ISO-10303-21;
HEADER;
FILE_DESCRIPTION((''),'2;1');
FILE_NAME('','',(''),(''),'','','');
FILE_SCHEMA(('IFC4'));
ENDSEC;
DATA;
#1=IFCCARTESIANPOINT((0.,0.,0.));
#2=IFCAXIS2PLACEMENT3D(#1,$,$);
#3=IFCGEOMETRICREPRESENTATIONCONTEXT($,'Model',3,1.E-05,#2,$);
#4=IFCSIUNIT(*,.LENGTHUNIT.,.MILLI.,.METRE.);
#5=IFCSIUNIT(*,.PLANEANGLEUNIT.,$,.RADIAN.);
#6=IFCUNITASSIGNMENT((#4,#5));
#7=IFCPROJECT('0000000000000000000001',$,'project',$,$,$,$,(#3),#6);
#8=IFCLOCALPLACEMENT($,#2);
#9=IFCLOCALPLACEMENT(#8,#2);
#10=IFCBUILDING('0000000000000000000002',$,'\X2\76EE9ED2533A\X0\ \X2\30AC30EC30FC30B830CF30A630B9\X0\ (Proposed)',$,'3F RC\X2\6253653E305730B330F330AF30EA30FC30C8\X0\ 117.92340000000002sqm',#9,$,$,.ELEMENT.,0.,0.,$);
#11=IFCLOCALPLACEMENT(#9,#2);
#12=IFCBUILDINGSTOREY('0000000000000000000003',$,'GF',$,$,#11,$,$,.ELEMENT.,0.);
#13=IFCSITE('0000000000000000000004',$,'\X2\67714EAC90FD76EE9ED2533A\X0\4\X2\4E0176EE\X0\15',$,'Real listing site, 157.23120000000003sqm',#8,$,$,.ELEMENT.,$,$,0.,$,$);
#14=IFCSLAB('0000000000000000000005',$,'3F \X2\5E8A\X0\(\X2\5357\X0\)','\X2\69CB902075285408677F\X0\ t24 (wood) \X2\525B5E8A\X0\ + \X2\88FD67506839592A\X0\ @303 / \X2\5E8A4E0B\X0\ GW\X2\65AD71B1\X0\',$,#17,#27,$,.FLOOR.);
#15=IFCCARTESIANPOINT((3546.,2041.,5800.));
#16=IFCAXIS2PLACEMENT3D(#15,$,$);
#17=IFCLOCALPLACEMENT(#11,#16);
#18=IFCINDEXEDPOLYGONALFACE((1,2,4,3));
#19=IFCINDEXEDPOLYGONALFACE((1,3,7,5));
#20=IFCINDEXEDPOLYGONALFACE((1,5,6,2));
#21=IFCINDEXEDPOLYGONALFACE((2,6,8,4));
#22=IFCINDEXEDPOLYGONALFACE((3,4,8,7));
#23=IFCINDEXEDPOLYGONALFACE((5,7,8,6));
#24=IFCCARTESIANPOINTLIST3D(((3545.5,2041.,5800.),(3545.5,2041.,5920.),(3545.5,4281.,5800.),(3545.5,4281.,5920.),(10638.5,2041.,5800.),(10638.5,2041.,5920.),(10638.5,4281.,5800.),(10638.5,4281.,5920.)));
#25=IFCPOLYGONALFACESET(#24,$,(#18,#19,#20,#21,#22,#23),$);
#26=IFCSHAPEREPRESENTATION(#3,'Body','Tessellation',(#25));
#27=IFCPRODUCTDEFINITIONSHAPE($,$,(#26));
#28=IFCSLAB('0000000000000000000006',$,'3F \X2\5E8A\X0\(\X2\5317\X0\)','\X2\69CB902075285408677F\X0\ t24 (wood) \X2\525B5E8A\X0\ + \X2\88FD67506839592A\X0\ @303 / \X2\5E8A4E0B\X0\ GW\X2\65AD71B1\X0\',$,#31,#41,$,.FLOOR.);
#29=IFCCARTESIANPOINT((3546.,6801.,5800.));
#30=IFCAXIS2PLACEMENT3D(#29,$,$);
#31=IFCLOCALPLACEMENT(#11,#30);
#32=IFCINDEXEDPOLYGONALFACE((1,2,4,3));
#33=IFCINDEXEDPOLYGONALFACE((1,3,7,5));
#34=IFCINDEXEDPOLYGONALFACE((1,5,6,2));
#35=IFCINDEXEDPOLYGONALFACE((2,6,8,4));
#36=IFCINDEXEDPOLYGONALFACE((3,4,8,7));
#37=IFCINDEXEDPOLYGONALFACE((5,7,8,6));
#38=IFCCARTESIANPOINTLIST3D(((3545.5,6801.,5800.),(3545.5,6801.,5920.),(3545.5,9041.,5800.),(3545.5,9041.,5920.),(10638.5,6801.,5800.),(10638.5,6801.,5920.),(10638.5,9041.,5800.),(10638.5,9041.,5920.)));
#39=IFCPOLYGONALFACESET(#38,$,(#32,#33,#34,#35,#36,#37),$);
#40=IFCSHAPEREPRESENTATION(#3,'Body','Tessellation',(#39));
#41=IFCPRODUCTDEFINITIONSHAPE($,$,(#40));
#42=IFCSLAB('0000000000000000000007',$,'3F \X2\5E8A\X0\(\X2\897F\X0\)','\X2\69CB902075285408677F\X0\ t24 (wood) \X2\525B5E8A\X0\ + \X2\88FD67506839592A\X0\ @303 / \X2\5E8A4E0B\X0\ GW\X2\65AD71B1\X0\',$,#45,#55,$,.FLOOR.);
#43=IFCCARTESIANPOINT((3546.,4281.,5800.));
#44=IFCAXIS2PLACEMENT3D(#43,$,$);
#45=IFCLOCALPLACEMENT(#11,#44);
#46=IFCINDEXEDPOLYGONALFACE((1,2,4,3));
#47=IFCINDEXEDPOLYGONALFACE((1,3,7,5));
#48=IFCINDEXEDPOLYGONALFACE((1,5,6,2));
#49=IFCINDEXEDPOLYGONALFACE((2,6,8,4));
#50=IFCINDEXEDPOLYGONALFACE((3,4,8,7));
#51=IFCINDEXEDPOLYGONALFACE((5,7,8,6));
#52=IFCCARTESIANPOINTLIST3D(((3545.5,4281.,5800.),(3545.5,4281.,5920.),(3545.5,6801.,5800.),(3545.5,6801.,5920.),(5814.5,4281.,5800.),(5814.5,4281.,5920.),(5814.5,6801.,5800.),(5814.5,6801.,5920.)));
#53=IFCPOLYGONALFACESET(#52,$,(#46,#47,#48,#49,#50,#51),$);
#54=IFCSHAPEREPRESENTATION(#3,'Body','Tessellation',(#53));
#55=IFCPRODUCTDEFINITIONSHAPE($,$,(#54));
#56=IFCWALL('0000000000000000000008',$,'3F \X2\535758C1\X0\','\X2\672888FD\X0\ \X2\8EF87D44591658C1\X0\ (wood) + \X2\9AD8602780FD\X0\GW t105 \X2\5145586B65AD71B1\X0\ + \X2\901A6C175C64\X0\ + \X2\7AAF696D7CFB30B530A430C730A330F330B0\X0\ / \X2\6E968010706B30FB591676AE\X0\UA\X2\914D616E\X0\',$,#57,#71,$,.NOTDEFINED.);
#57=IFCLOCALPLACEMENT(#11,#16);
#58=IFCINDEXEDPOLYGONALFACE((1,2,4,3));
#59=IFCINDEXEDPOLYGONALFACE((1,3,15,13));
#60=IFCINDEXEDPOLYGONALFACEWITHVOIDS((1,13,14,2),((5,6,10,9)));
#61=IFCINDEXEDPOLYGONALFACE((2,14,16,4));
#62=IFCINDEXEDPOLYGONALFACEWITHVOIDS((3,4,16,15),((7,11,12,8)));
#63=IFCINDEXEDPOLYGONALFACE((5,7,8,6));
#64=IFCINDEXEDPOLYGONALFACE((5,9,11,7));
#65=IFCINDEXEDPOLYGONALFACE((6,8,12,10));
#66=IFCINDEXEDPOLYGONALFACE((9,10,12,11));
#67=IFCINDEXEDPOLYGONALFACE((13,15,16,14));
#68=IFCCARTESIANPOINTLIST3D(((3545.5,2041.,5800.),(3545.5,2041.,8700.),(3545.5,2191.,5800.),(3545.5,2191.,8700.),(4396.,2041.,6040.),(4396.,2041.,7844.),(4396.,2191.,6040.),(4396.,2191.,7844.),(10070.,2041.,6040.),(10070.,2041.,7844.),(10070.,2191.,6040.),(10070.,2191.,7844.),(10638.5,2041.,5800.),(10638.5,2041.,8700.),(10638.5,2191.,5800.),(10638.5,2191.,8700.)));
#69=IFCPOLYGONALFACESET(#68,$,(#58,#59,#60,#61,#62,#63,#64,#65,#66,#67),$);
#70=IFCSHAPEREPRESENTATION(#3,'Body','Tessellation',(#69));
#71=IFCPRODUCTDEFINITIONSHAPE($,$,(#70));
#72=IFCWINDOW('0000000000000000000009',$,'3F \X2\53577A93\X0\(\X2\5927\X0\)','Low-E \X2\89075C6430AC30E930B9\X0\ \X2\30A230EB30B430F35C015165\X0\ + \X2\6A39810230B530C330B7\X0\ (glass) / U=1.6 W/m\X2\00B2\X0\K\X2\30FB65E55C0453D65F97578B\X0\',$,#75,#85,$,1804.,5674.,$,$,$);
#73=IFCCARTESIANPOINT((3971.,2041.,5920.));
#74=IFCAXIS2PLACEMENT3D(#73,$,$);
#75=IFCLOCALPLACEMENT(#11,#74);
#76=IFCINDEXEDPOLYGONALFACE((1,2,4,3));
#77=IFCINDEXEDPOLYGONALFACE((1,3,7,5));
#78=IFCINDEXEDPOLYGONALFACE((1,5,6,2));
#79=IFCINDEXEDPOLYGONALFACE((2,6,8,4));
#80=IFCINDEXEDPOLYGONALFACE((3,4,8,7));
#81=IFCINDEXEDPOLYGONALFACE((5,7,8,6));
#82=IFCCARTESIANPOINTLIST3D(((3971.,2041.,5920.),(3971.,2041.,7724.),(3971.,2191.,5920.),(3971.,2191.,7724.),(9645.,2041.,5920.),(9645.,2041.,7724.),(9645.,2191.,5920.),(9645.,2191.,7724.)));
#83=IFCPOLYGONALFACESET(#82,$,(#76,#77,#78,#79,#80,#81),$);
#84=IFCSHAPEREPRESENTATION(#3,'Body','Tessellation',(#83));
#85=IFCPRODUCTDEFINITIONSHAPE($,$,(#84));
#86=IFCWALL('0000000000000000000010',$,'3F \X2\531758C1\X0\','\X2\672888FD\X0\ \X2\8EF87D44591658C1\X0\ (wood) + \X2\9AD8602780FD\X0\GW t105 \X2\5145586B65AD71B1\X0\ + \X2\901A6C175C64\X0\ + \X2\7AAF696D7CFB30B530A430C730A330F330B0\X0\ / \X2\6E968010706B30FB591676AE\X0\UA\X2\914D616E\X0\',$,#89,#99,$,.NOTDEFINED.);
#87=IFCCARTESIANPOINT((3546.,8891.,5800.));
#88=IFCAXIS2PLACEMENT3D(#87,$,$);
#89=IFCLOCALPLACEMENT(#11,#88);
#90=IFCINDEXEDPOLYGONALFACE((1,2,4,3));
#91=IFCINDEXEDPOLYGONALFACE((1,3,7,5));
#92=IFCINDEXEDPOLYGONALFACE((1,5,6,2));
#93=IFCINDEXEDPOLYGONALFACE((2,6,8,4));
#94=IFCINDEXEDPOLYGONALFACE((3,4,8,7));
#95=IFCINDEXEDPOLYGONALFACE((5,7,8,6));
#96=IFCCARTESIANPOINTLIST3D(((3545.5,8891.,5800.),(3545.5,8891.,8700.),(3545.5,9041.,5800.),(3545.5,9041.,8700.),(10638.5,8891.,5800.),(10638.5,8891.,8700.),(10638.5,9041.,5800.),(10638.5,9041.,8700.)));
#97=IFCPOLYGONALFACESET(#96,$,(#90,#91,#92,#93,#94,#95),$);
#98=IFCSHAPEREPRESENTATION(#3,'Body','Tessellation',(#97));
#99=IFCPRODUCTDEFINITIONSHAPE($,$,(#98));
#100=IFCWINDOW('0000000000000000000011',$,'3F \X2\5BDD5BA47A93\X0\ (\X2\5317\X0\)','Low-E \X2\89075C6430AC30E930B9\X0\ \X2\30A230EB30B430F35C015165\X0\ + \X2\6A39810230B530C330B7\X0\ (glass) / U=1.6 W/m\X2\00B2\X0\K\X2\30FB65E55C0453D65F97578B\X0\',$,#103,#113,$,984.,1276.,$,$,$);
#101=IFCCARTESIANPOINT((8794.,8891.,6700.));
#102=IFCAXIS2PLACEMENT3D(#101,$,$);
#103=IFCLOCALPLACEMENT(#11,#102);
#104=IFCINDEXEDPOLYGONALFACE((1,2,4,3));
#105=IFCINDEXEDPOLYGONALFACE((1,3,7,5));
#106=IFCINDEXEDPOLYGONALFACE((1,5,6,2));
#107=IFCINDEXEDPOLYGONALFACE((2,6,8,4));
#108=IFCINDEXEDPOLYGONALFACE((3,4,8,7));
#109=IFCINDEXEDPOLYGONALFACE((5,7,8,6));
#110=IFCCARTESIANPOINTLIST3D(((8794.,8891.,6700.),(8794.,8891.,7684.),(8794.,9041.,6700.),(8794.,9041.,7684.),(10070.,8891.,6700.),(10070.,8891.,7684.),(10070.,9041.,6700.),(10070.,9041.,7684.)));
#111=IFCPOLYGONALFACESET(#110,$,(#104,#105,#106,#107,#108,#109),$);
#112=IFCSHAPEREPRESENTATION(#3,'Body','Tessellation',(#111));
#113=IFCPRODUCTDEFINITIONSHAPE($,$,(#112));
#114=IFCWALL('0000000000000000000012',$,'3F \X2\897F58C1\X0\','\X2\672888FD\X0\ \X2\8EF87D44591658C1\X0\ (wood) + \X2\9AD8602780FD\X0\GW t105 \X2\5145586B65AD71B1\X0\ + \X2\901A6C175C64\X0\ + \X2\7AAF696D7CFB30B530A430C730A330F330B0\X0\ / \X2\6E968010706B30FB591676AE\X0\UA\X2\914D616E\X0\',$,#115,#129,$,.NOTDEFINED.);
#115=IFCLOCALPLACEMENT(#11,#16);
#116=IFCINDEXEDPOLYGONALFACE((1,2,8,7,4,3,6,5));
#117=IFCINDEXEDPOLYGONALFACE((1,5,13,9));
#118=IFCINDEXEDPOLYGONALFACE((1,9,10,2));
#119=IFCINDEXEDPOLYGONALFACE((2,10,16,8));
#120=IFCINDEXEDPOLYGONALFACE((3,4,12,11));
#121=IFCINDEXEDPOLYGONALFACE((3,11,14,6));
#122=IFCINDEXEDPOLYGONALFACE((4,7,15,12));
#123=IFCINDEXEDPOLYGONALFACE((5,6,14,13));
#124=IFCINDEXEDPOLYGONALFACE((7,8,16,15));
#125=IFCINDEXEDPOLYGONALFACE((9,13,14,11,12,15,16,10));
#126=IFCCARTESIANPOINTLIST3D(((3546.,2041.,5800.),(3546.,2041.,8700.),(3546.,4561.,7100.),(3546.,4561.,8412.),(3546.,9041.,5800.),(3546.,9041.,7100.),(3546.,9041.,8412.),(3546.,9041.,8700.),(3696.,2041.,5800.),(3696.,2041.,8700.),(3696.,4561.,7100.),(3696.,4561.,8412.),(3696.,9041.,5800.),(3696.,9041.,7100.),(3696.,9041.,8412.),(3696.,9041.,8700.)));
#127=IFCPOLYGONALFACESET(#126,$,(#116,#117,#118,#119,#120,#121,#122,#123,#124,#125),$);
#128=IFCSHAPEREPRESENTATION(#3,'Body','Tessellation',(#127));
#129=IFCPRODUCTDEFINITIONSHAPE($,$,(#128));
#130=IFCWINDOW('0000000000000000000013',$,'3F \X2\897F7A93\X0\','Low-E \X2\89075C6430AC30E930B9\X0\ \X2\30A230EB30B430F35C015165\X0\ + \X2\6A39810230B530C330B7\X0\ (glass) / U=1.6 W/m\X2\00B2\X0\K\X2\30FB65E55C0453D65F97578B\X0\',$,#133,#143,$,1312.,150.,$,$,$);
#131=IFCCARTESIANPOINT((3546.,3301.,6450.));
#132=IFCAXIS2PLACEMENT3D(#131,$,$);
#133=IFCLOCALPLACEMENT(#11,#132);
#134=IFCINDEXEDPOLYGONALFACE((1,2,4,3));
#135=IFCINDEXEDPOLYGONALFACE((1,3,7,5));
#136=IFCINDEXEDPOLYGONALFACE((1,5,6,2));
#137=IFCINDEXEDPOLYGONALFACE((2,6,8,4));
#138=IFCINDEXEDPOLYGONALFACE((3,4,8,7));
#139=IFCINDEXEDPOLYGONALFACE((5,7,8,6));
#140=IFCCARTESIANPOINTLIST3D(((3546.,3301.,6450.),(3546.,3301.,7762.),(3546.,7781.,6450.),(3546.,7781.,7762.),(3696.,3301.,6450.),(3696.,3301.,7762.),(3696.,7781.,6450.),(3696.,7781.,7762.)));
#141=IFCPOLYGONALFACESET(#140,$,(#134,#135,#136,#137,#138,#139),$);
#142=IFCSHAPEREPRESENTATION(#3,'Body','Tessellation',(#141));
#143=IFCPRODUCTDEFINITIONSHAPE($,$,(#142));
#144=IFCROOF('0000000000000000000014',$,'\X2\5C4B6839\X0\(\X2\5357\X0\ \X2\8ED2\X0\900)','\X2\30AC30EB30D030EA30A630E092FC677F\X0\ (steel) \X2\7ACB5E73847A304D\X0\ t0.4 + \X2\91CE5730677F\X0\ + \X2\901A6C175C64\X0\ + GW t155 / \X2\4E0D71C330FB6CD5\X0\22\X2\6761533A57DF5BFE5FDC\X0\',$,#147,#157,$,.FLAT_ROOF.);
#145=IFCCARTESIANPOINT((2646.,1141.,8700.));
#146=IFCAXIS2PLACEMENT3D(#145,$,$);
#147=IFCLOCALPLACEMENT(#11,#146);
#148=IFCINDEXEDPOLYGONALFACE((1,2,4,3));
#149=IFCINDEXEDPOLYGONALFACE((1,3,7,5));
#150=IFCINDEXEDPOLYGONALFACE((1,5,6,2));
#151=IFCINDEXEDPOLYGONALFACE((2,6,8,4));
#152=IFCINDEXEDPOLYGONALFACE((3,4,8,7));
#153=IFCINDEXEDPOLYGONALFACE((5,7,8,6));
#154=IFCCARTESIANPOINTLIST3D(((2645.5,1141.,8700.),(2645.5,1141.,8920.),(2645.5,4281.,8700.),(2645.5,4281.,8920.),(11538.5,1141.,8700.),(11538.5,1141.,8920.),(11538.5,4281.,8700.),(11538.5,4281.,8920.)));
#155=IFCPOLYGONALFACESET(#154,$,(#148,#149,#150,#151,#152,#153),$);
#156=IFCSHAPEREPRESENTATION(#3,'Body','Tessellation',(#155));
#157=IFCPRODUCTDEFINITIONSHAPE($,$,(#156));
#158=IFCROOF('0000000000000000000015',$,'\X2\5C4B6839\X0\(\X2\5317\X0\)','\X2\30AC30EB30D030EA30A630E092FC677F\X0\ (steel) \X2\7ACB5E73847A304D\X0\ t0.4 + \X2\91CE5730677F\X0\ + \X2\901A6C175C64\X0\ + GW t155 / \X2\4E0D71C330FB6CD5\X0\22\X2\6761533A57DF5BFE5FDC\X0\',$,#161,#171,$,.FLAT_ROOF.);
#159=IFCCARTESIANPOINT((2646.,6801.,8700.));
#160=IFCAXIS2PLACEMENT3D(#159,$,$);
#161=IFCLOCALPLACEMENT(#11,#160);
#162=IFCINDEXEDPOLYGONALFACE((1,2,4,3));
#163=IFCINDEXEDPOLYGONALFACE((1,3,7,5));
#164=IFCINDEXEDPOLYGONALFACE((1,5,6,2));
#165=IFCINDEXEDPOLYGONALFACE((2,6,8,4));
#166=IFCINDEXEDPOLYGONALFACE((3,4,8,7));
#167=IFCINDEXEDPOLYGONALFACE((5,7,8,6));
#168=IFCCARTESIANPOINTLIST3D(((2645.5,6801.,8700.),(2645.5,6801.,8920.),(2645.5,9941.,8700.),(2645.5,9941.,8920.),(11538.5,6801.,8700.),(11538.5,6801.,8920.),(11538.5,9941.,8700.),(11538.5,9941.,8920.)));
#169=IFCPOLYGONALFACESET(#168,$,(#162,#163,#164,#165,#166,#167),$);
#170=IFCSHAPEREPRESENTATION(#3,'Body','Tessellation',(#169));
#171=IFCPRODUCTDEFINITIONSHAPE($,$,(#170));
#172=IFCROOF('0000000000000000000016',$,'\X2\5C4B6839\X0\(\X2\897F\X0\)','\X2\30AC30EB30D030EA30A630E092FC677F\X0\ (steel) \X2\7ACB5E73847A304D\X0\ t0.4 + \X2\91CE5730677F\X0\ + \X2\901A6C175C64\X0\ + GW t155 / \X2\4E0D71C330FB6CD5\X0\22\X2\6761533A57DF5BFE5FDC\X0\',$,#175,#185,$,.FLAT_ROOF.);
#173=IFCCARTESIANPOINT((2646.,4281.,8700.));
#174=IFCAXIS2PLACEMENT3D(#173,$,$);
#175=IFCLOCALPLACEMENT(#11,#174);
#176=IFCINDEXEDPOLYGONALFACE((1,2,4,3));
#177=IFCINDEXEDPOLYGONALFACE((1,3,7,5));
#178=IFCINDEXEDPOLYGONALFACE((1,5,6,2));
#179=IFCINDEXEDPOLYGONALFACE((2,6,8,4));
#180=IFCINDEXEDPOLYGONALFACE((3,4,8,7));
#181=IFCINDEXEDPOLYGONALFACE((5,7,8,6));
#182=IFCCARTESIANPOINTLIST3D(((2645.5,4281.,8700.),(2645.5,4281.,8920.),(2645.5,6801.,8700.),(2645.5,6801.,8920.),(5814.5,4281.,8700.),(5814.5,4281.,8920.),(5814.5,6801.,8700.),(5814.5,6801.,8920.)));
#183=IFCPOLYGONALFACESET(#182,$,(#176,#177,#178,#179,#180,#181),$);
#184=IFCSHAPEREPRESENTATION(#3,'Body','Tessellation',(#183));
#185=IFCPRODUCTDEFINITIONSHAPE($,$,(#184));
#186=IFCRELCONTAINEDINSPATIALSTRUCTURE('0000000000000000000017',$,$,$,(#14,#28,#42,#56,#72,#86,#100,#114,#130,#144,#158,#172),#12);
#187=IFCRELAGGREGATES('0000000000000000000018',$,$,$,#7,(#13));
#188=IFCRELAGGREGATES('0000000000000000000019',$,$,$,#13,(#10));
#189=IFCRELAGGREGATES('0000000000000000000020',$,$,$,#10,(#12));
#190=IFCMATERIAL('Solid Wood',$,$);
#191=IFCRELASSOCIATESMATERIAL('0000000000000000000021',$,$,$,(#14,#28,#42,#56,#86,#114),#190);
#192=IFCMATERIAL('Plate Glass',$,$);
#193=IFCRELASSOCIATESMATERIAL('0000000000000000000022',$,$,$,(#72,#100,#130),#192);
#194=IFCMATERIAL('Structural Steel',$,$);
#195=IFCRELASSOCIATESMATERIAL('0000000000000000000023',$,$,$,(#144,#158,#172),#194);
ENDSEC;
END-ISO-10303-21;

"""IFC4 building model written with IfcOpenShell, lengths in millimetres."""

from ifc_helpers import new_model, si_unit, frame, frame_2d, origin, place, context, project, spatial, rectangle, extrude, material, element, fill, save


model = new_model("IFC4")

# Units and contexts
model_context = context("Model", 3, precision=1e-05, world=origin())
ifc_project = project(units=[si_unit("LENGTHUNIT", "METRE", prefix="MILLI"), si_unit("PLANEANGLEUNIT", "RADIAN")], contexts=[model_context])

# Site, building, storey
site_placement = place(None, origin())
site = spatial("IfcSite", under=ifc_project, at=site_placement, Name="東京都目黒区4丁目15", ObjectType="Real listing site, 157.23120000000003sqm", CompositionType="ELEMENT", RefElevation=0.0)
building_placement = place(site_placement, origin())
building = spatial("IfcBuilding", under=site, at=building_placement, Name="目黒区 ガレージハウス (Proposed)", ObjectType="3F RC打放しコンクリート 117.92340000000002sqm", CompositionType="ELEMENT", ElevationOfRefHeight=0.0, ElevationOfTerrain=0.0)
storey_placement = place(building_placement, origin())
storey = spatial("IfcBuildingStorey", under=building, at=storey_placement, Name="GF", CompositionType="ELEMENT", Elevation=0.0)

# Slabs
ifc_material_1 = material(Name="Solid Wood")
slab_1_placement = place(storey_placement, frame((3546.0, 2041.0, 5800.0)))
element("IfcSlab", 1, at=slab_1_placement, inside=storey, material=ifc_material_1, Name="3F 床(南)", Description="構造用合板 t24 (wood) 剛床 + 製材根太 @303 / 床下 GW断熱", PredefinedType="FLOOR", context=model_context, shape_type="SweptSolid", body=[
    extrude(rectangle(XDim=7093.0, YDim=2240.0, at=frame_2d((3546.0, 1120.0))), frame((3546.0, 2041.0, 5800.0)), (0.0, 0.0, 1.0), 120.0),
])
slab_2_placement = place(storey_placement, frame((3546.0, 6801.0, 5800.0)))
element("IfcSlab", 2, at=slab_2_placement, inside=storey, material=ifc_material_1, Name="3F 床(北)", Description="構造用合板 t24 (wood) 剛床 + 製材根太 @303 / 床下 GW断熱", PredefinedType="FLOOR", context=model_context, shape_type="SweptSolid", body=[
    extrude(rectangle(XDim=7093.0, YDim=2240.0, at=frame_2d((3546.0, 1120.0))), frame((3546.0, 6801.0, 5800.0)), (0.0, 0.0, 1.0), 120.0),
])
slab_3_placement = place(storey_placement, frame((3546.0, 4281.0, 5800.0)))
element("IfcSlab", 3, at=slab_3_placement, inside=storey, material=ifc_material_1, Name="3F 床(西)", Description="構造用合板 t24 (wood) 剛床 + 製材根太 @303 / 床下 GW断熱", PredefinedType="FLOOR", context=model_context, shape_type="SweptSolid", body=[
    extrude(rectangle(XDim=2269.0, YDim=2520.0, at=frame_2d((1134.0, 1260.0))), frame((3546.0, 4281.0, 5800.0)), (0.0, 0.0, 1.0), 120.0),
])

# Walls, openings, windows
wall_1_placement = place(storey_placement, frame((3546.0, 2041.0, 5800.0)))
wall_1 = element("IfcWall", 4, at=wall_1_placement, inside=storey, material=ifc_material_1, Name="3F 南壁", Description="木製 軸組外壁 (wood) + 高性能GW t105 充填断熱 + 通気層 + 窯業系サイディング / 準耐火・外皮UA配慮", PredefinedType="NOTDEFINED", context=model_context, shape_type="SweptSolid", body=[
    extrude(rectangle(XDim=7093.0, YDim=150.0, at=frame_2d((3546.0, 75.0))), frame((3546.0, 2041.0, 5800.0)), (0.0, 0.0, 1.0), 2900.0),
])
opening_1_placement = place(storey_placement, frame((3971.0, 2041.0, 5920.0)))
opening_1 = element("IfcOpeningElement", 5, at=opening_1_placement, cuts=wall_1, PredefinedType="NOTDEFINED", context=model_context, shape_type="SweptSolid", body=[
    extrude(rectangle(XDim=5674.0, YDim=150.0, at=frame_2d((2837.0, 75.0))), frame((3971.0, 2041.0, 5920.0)), (0.0, 0.0, 1.0), 1804.0),
])
ifc_material_2 = material(Name="Plate Glass")
window_1_placement = place(storey_placement, frame((3971.0, 2041.0, 5920.0)))
window_1 = element("IfcWindow", 6, at=window_1_placement, inside=storey, material=ifc_material_2, Name="3F 南窓(大)", Description="Low-E 複層ガラス アルゴン封入 + 樹脂サッシ (glass) / U=1.6 W/m²K・日射取得型", OverallHeight=1804.0, OverallWidth=5674.0, context=model_context, shape_type="SweptSolid", body=[
    extrude(rectangle(XDim=5674.0, YDim=150.0, at=frame_2d((2837.0, 75.0))), frame((3971.0, 2041.0, 5920.0)), (0.0, 0.0, 1.0), 1804.0),
])
fill(opening_1, window_1)
wall_2_placement = place(storey_placement, frame((3546.0, 8891.0, 5800.0)))
wall_2 = element("IfcWall", 7, at=wall_2_placement, inside=storey, material=ifc_material_1, Name="3F 北壁", Description="木製 軸組外壁 (wood) + 高性能GW t105 充填断熱 + 通気層 + 窯業系サイディング / 準耐火・外皮UA配慮", PredefinedType="NOTDEFINED", context=model_context, shape_type="SweptSolid", body=[
    extrude(rectangle(XDim=7093.0, YDim=150.0, at=frame_2d((3546.0, 75.0))), frame((3546.0, 8891.0, 5800.0)), (0.0, 0.0, 1.0), 2900.0),
])
opening_2_placement = place(storey_placement, frame((8794.0, 8891.0, 6700.0)))
opening_2 = element("IfcOpeningElement", 8, at=opening_2_placement, cuts=wall_2, PredefinedType="NOTDEFINED", context=model_context, shape_type="SweptSolid", body=[
    extrude(rectangle(XDim=1276.0, YDim=150.0, at=frame_2d((638.0, 75.0))), frame((8794.0, 8891.0, 6700.0)), (0.0, 0.0, 1.0), 984.0),
])
window_2_placement = place(storey_placement, frame((8794.0, 8891.0, 6700.0)))
window_2 = element("IfcWindow", 9, at=window_2_placement, inside=storey, material=ifc_material_2, Name="3F 寝室窓 (北)", Description="Low-E 複層ガラス アルゴン封入 + 樹脂サッシ (glass) / U=1.6 W/m²K・日射取得型", OverallHeight=984.0, OverallWidth=1276.0, context=model_context, shape_type="SweptSolid", body=[
    extrude(rectangle(XDim=1276.0, YDim=150.0, at=frame_2d((638.0, 75.0))), frame((8794.0, 8891.0, 6700.0)), (0.0, 0.0, 1.0), 984.0),
])
fill(opening_2, window_2)
wall_3_placement = place(storey_placement, frame((3546.0, 2041.0, 5800.0)))
wall_3 = element("IfcWall", 10, at=wall_3_placement, inside=storey, material=ifc_material_1, Name="3F 西壁", Description="木製 軸組外壁 (wood) + 高性能GW t105 充填断熱 + 通気層 + 窯業系サイディング / 準耐火・外皮UA配慮", PredefinedType="NOTDEFINED", context=model_context, shape_type="SweptSolid", body=[
    extrude(rectangle(XDim=150.0, YDim=7000.0, at=frame_2d((75.0, 3500.0))), frame((3546.0, 2041.0, 5800.0)), (0.0, 0.0, 1.0), 2900.0),
])
opening_3_placement = place(storey_placement, frame((3546.0, 3301.0, 6450.0)))
opening_3 = element("IfcOpeningElement", 11, at=opening_3_placement, cuts=wall_3, PredefinedType="NOTDEFINED", context=model_context, shape_type="SweptSolid", body=[
    extrude(rectangle(XDim=150.0, YDim=4480.0, at=frame_2d((75.0, 2240.0))), frame((3546.0, 3301.0, 6450.0)), (0.0, 0.0, 1.0), 1312.0),
])
window_3_placement = place(storey_placement, frame((3546.0, 3301.0, 6450.0)))
window_3 = element("IfcWindow", 12, at=window_3_placement, inside=storey, material=ifc_material_2, Name="3F 西窓", Description="Low-E 複層ガラス アルゴン封入 + 樹脂サッシ (glass) / U=1.6 W/m²K・日射取得型", OverallHeight=1312.0, OverallWidth=150.0, context=model_context, shape_type="SweptSolid", body=[
    extrude(rectangle(XDim=150.0, YDim=4480.0, at=frame_2d((75.0, 2240.0))), frame((3546.0, 3301.0, 6450.0)), (0.0, 0.0, 1.0), 1312.0),
])
fill(opening_3, window_3)

# Roofs
ifc_material_3 = material(Name="Structural Steel")
roof_1_placement = place(storey_placement, frame((2646.0, 1141.0, 8700.0)))
element("IfcRoof", 13, at=roof_1_placement, inside=storey, material=ifc_material_3, Name="屋根(南 軒900)", Description="ガルバリウム鋼板 (steel) 立平葺き t0.4 + 野地板 + 通気層 + GW t155 / 不燃・法22条区域対応", PredefinedType="FLAT_ROOF", context=model_context, shape_type="SweptSolid", body=[
    extrude(rectangle(XDim=8893.0, YDim=3140.0, at=frame_2d((4446.0, 1570.0))), frame((2646.0, 1141.0, 8700.0)), (0.0, 0.0, 1.0), 220.0),
])
roof_2_placement = place(storey_placement, frame((2646.0, 6801.0, 8700.0)))
element("IfcRoof", 14, at=roof_2_placement, inside=storey, material=ifc_material_3, Name="屋根(北)", Description="ガルバリウム鋼板 (steel) 立平葺き t0.4 + 野地板 + 通気層 + GW t155 / 不燃・法22条区域対応", PredefinedType="FLAT_ROOF", context=model_context, shape_type="SweptSolid", body=[
    extrude(rectangle(XDim=8893.0, YDim=3140.0, at=frame_2d((4446.0, 1570.0))), frame((2646.0, 6801.0, 8700.0)), (0.0, 0.0, 1.0), 220.0),
])
roof_3_placement = place(storey_placement, frame((2646.0, 4281.0, 8700.0)))
element("IfcRoof", 15, at=roof_3_placement, inside=storey, material=ifc_material_3, Name="屋根(西)", Description="ガルバリウム鋼板 (steel) 立平葺き t0.4 + 野地板 + 通気層 + GW t155 / 不燃・法22条区域対応", PredefinedType="FLAT_ROOF", context=model_context, shape_type="SweptSolid", body=[
    extrude(rectangle(XDim=3169.0, YDim=2520.0, at=frame_2d((1584.0, 1260.0))), frame((2646.0, 4281.0, 8700.0)), (0.0, 0.0, 1.0), 220.0),
])

save(model, "model.ifc")
